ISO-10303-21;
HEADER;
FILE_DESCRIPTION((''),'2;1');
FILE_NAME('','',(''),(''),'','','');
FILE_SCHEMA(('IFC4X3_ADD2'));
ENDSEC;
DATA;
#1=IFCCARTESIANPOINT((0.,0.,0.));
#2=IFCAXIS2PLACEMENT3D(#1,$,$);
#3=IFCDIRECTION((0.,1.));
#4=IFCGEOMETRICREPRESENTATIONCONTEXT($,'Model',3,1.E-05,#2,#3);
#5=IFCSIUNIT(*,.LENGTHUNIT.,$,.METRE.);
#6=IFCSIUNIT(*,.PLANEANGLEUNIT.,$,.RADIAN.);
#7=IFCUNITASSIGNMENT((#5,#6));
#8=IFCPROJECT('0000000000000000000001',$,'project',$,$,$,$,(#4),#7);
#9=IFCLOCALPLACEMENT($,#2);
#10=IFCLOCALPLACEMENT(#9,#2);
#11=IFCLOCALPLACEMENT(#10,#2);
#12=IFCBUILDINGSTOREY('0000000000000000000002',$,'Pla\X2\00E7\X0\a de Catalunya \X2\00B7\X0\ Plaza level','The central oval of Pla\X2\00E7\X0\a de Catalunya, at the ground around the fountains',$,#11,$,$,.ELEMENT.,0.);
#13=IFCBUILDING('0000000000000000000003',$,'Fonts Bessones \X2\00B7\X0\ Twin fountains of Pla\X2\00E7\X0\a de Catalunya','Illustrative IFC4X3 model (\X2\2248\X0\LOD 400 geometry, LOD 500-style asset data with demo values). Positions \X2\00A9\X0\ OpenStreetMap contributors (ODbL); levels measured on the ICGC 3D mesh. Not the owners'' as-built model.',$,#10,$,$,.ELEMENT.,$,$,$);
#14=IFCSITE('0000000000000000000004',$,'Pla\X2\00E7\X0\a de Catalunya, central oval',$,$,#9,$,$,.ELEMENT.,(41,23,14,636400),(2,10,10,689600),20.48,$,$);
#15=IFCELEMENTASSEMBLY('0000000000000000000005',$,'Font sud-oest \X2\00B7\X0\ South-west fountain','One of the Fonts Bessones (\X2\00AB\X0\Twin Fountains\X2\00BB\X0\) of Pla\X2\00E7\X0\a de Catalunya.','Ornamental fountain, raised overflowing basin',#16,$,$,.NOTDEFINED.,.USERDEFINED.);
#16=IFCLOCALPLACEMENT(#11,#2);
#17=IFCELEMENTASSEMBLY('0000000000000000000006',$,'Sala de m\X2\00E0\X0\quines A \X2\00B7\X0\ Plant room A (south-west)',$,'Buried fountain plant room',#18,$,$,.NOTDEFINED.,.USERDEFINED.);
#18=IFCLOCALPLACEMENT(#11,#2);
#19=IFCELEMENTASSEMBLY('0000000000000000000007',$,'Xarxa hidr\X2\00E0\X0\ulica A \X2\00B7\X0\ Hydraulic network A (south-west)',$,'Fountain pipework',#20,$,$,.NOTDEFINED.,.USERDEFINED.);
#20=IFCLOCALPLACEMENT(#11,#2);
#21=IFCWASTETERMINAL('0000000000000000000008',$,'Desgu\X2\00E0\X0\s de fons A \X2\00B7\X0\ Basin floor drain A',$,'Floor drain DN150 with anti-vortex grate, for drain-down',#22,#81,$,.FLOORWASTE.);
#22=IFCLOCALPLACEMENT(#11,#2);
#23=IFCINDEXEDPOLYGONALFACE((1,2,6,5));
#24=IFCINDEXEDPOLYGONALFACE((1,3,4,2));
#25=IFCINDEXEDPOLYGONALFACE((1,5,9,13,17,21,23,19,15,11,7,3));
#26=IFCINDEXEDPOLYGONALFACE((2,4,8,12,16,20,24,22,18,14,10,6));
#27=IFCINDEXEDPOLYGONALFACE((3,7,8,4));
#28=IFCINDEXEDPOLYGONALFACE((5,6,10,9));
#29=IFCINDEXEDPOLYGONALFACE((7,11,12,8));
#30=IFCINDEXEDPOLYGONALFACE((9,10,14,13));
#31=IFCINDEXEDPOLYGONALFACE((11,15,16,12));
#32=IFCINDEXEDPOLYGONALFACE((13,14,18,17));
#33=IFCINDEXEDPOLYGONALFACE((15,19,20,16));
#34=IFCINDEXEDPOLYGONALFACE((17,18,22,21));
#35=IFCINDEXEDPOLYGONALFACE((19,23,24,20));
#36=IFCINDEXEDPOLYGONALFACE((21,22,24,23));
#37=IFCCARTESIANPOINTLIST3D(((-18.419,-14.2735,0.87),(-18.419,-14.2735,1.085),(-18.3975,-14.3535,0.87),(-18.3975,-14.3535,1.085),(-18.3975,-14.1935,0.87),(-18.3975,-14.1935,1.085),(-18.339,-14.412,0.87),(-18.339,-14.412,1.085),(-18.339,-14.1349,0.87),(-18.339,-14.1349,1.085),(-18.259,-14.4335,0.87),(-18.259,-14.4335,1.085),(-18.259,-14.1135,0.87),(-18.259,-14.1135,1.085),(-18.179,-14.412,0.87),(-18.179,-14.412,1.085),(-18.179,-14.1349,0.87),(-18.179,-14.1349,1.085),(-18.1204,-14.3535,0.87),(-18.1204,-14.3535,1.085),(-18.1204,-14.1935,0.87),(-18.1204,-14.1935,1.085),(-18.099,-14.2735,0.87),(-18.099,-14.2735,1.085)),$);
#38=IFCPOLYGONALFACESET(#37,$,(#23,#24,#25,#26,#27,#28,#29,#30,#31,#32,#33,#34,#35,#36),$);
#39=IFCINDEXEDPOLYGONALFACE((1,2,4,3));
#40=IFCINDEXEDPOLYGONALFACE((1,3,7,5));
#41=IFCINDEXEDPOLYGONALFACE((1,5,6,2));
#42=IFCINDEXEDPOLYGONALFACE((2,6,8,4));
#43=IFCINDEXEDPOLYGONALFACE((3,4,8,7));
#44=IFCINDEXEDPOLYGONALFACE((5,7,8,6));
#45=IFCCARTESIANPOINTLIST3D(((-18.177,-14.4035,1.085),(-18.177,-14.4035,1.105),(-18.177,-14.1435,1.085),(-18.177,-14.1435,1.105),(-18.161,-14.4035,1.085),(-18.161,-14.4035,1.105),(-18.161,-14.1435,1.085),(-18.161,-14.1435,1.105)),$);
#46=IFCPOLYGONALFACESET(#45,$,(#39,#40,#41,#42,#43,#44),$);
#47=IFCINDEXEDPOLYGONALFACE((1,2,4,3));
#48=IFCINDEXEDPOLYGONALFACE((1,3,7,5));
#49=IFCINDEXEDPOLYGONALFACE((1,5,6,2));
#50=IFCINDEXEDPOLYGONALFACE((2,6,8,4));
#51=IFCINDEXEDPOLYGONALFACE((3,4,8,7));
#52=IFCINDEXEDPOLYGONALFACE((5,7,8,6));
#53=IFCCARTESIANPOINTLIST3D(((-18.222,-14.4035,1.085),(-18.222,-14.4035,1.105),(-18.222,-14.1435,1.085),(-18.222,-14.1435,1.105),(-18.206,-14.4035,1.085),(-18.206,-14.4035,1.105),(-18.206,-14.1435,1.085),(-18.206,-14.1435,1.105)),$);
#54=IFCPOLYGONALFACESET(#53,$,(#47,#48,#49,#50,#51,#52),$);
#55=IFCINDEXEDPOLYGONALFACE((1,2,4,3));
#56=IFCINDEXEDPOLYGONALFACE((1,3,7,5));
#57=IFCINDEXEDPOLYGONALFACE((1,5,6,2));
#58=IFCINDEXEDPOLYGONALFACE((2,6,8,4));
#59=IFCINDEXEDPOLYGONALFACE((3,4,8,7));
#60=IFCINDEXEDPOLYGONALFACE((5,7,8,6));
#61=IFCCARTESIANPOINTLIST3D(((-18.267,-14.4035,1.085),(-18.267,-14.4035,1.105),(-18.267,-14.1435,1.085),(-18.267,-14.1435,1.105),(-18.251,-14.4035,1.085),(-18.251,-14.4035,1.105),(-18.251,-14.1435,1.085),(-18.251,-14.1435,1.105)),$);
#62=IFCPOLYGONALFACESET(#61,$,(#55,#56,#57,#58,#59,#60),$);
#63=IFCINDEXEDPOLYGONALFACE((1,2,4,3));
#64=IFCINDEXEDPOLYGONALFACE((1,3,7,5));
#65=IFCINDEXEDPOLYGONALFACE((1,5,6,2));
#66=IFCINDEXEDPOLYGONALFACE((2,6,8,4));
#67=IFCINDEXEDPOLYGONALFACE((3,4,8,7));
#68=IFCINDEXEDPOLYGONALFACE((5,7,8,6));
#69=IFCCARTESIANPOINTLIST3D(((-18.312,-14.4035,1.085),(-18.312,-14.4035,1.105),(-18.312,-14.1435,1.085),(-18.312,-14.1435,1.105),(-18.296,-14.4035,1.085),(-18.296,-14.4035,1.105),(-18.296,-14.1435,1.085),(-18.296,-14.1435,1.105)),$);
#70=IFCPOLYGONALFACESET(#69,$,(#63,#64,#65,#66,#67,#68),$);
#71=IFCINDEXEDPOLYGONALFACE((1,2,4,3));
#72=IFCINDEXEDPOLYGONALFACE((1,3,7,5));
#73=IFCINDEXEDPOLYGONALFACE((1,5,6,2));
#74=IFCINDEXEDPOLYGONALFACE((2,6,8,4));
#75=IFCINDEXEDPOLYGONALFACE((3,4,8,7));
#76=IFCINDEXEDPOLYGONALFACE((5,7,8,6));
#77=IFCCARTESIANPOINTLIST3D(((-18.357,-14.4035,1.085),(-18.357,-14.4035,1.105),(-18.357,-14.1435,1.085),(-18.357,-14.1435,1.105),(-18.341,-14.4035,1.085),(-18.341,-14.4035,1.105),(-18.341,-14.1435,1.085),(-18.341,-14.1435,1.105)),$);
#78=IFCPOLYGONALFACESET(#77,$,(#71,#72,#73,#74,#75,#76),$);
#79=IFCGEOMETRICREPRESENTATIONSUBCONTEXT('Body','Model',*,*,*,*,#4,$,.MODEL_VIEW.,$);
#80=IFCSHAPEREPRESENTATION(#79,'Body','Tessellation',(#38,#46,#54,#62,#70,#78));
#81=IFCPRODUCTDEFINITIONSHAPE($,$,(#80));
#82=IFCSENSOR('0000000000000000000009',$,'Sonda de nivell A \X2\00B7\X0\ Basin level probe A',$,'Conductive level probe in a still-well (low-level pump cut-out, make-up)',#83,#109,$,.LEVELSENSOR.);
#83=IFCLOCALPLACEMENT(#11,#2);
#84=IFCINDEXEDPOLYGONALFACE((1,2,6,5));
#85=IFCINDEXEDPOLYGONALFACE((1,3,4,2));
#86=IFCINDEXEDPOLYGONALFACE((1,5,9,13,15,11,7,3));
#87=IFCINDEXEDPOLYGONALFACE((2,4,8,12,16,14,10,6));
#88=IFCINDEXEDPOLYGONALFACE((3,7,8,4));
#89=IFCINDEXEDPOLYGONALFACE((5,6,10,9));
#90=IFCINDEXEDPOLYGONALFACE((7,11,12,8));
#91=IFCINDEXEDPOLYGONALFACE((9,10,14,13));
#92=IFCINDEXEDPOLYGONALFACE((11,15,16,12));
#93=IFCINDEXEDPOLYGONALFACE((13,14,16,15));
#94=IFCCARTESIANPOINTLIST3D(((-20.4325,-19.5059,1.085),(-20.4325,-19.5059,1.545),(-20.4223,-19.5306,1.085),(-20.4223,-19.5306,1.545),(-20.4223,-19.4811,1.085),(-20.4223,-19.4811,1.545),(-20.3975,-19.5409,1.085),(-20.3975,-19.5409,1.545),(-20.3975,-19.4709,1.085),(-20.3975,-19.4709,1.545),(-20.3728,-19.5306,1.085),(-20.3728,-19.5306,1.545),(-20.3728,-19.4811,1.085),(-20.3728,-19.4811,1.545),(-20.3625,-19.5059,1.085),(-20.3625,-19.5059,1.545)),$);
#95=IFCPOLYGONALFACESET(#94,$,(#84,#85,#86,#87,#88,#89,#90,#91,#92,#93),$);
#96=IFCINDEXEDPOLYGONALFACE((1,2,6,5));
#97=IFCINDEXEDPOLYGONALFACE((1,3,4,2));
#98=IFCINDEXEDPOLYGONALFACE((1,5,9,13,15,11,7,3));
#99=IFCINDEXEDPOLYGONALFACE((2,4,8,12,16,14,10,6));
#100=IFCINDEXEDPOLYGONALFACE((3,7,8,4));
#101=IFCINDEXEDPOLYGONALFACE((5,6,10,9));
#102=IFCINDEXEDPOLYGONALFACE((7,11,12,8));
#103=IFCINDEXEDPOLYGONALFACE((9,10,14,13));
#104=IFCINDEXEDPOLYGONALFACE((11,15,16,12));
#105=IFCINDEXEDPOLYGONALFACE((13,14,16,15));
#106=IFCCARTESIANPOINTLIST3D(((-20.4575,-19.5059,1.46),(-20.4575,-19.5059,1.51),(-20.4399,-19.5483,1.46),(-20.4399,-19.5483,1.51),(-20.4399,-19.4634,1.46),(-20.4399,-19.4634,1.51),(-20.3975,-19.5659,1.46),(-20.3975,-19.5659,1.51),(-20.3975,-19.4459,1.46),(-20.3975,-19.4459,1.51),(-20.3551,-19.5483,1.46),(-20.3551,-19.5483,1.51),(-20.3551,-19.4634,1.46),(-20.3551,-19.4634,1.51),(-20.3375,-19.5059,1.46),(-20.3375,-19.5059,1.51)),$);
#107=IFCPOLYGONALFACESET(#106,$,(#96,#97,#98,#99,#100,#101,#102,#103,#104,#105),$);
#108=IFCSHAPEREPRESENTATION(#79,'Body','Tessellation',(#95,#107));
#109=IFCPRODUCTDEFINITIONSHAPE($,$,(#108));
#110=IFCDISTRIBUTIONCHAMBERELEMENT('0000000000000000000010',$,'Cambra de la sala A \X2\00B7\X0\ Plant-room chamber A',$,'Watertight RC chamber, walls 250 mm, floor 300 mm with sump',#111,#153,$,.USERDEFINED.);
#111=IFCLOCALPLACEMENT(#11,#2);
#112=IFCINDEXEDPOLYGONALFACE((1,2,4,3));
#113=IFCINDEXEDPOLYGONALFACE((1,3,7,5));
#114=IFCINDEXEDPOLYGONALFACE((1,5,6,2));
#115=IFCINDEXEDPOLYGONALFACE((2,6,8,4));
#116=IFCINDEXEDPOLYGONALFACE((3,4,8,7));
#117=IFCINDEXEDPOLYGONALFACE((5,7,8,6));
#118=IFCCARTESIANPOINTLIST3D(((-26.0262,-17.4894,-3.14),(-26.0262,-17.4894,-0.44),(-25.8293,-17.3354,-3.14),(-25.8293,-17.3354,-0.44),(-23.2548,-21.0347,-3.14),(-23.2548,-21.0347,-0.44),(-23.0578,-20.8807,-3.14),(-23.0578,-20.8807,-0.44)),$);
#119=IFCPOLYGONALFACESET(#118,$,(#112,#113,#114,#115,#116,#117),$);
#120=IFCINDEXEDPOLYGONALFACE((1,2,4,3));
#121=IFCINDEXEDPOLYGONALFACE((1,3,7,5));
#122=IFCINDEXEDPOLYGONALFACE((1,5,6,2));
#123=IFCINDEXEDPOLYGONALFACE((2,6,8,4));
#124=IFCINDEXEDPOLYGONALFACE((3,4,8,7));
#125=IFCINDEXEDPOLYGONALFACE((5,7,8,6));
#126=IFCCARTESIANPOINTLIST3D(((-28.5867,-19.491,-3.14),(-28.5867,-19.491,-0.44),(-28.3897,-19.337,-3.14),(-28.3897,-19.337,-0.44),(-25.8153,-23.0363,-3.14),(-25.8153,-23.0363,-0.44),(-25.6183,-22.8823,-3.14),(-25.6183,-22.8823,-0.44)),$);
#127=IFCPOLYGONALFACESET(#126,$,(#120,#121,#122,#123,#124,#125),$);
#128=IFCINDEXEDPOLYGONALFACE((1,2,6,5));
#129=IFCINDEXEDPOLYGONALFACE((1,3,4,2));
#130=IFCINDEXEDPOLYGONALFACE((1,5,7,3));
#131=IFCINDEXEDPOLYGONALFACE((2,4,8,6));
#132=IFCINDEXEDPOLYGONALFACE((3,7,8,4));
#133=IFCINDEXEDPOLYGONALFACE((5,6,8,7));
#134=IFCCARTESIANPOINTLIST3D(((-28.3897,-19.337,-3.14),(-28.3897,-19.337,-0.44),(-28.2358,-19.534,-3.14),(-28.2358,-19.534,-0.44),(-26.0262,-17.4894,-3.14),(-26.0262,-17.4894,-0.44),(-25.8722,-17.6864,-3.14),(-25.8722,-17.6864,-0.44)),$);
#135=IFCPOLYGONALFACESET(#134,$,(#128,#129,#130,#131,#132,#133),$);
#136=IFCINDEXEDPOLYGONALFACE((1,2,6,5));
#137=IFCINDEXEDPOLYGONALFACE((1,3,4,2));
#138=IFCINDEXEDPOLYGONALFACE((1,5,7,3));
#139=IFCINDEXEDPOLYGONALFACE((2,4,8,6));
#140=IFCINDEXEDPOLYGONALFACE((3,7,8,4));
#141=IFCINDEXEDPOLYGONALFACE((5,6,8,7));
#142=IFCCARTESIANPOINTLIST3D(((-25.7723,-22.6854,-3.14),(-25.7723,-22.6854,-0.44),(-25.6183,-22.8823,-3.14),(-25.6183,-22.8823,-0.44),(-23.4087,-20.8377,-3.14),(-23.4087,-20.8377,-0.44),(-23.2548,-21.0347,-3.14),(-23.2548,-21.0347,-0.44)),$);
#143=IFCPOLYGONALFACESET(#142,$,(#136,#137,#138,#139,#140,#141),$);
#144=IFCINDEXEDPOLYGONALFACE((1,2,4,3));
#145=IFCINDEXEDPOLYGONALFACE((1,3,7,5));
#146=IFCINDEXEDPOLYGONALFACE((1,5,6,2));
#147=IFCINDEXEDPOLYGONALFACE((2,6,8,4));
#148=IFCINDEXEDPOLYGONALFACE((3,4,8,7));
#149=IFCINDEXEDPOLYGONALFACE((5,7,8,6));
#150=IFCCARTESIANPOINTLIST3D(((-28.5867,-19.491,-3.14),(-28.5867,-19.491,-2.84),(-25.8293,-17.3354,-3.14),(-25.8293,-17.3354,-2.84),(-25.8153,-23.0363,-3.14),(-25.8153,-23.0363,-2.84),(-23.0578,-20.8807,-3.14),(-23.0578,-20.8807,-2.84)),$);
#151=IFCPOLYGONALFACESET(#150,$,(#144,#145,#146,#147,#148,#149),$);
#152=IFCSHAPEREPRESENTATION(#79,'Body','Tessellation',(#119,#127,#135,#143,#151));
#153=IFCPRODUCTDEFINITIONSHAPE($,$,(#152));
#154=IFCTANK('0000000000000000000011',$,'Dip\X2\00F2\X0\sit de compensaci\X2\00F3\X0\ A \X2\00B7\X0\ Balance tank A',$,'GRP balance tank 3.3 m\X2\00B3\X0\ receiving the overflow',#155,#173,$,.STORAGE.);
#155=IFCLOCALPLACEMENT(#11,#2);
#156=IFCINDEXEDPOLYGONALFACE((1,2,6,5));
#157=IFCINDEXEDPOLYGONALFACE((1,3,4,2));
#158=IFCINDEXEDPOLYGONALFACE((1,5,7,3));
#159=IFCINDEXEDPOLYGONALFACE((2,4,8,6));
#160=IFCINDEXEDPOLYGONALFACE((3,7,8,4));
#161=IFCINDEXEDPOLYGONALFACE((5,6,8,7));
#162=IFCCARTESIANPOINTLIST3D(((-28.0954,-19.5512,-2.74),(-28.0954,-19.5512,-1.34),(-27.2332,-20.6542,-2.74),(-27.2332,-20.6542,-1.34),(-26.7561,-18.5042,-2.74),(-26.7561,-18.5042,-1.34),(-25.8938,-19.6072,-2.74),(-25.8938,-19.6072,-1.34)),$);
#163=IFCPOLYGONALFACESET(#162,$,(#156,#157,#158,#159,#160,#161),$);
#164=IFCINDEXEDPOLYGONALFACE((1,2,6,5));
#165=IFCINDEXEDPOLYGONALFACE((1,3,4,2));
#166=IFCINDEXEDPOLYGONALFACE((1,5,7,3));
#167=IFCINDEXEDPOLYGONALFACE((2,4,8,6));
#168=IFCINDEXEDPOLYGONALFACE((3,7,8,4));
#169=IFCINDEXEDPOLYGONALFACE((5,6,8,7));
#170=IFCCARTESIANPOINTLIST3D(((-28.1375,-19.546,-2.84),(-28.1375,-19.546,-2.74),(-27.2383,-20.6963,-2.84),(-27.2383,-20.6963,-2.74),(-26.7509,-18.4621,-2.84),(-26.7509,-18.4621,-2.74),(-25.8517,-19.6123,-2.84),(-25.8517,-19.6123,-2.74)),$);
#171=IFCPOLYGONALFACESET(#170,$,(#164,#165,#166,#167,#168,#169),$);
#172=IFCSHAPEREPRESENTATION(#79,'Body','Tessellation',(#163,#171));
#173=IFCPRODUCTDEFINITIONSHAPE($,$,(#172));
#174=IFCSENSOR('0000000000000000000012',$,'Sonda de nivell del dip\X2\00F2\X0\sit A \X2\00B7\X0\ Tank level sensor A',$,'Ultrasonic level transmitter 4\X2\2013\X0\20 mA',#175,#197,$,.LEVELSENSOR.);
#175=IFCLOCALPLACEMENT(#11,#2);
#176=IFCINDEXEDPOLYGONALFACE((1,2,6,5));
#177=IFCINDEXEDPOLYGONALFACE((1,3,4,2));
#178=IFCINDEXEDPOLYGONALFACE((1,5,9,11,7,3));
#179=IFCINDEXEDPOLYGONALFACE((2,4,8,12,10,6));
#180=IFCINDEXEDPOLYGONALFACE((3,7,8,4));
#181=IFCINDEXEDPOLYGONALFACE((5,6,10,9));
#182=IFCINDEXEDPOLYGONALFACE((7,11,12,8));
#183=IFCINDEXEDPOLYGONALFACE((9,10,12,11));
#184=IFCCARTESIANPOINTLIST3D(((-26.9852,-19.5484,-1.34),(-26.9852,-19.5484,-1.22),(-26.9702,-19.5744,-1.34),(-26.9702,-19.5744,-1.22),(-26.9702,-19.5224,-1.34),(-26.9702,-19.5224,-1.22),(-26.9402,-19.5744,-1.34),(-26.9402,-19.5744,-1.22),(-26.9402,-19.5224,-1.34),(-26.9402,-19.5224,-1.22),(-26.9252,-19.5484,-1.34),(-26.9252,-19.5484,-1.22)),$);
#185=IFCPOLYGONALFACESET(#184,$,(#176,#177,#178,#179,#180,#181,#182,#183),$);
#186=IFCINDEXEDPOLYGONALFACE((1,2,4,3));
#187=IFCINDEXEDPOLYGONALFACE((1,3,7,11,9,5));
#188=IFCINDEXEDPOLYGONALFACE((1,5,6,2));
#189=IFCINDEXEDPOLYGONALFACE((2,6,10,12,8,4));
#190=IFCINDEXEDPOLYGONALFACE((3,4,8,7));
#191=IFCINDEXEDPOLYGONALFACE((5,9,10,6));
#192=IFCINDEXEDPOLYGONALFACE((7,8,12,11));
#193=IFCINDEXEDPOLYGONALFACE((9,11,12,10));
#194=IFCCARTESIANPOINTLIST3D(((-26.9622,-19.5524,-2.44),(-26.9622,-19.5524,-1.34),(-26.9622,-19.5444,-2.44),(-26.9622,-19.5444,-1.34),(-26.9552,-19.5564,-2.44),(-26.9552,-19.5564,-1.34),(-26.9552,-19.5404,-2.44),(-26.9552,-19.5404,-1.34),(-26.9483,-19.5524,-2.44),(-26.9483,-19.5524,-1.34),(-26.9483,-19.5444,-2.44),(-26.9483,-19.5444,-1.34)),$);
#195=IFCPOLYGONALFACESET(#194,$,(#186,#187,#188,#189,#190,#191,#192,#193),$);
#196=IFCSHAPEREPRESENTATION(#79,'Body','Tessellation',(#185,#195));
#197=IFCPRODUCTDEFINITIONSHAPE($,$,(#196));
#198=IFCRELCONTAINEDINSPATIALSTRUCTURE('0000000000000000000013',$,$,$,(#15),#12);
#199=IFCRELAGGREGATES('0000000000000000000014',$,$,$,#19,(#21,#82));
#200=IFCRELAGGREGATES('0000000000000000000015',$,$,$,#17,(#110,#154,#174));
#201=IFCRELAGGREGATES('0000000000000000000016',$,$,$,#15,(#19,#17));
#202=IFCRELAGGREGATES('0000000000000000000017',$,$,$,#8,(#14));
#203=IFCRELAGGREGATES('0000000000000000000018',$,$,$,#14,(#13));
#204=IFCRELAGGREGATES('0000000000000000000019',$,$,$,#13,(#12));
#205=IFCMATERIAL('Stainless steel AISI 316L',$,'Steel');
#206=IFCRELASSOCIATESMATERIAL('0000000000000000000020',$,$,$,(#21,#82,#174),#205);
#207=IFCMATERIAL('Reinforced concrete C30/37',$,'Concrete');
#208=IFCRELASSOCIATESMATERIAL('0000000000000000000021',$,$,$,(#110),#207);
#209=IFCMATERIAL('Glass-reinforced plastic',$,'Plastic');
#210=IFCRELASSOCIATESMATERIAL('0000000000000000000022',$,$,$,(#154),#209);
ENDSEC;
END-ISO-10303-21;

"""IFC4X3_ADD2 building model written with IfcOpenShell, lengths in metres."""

from ifc_helpers import new_model, si_unit, direction, frame, frame_2d, origin, place, context, subcontext, project, spatial, polyline, rectangle, outline, extrude, material, element, aggregate, save


model = new_model("IFC4X3_ADD2")

# Units and contexts
model_context = context("Model", 3, precision=1e-05, world=origin(), true_north=direction((0.0, 1.0)))
body_context = subcontext(model_context, "Body", "Model", "MODEL_VIEW")
ifc_project = project(units=[si_unit("LENGTHUNIT", "METRE"), si_unit("PLANEANGLEUNIT", "RADIAN")], contexts=[model_context])

# Site, building, storey
site_placement = place(None, origin())
site = spatial("IfcSite", under=ifc_project, at=site_placement, Name="Plaça de Catalunya, central oval", CompositionType="ELEMENT", RefLatitude=(41, 23, 14, 636400), RefLongitude=(2, 10, 10, 689600), RefElevation=20.48)
building_placement = place(site_placement, origin())
building = spatial("IfcBuilding", under=site, at=building_placement, Name="Fonts Bessones · Twin fountains of Plaça de Catalunya", Description="Illustrative IFC4X3 model (≈LOD 400 geometry, LOD 500-style asset data with demo values). Positions © OpenStreetMap contributors (ODbL); levels measured on the ICGC 3D mesh. Not the owners' as-built model.", CompositionType="ELEMENT")
storey_placement = place(building_placement, origin())
storey = spatial("IfcBuildingStorey", under=building, at=storey_placement, Name="Plaça de Catalunya · Plaza level", Description="The central oval of Plaça de Catalunya, at the ground around the fountains", CompositionType="ELEMENT", Elevation=0.0)

# Shared definitions
ifc_material_1 = material(Name="Reinforced concrete C30/37", Category="Concrete")

# Element assemblies
assembly_1_placement = place(building_placement, origin())
assembly_1 = element("IfcElementAssembly", 1, at=assembly_1_placement, inside=storey, Name="Font sud-oest · South-west fountain", Description="One of the Fonts Bessones («Twin Fountains») of Plaça de Catalunya.", ObjectType="Ornamental fountain, raised overflowing basin", AssemblyPlace="NOTDEFINED", PredefinedType="USERDEFINED")
assembly_2_placement = place(building_placement, origin())
assembly_2 = element("IfcElementAssembly", 2, at=assembly_2_placement, Name="Sala de màquines A · Plant room A (south-west)", ObjectType="Buried fountain plant room", AssemblyPlace="NOTDEFINED", PredefinedType="USERDEFINED")

# Shared definitions
ifc_material_2 = material(Name="Stainless steel AISI 316L", Category="Steel")

# Element assembly, waste terminal, sensor
assembly_3_placement = place(building_placement, origin())
assembly_3 = element("IfcElementAssembly", 3, at=assembly_3_placement, Name="Xarxa hidràulica A · Hydraulic network A (south-west)", ObjectType="Fountain pipework", AssemblyPlace="NOTDEFINED", PredefinedType="USERDEFINED")
waste_terminal_placement = place(building_placement, origin())
waste_terminal = element("IfcWasteTerminal", 4, at=waste_terminal_placement, material=ifc_material_2, Name="Desguàs de fons A · Basin floor drain A", ObjectType="Floor drain DN150 with anti-vortex grate, for drain-down", PredefinedType="FLOORWASTE", context=body_context, shape_type="SweptSolid", body=[
    extrude(outline(polyline([(-18.099, -14.2735), (-18.1204, -14.1935), (-18.179, -14.1349), (-18.259, -14.1135), (-18.339, -14.1349), (-18.3975, -14.1935), (-18.419, -14.2735), (-18.3975, -14.3535), (-18.339, -14.412), (-18.259, -14.4335), (-18.179, -14.412), (-18.1204, -14.3535), (-18.099, -14.2735)])), frame((0.0, 0.0, 0.87)), (0.0, 0.0, 1.0), 0.215),
    extrude(rectangle(XDim=0.26, YDim=0.016, at=frame_2d((0.0, 0.0), x_axis=(0.0, 1.0))), frame((-18.169, -14.2735, 1.085)), (0.0, 0.0, 1.0), 0.02),
    extrude(rectangle(XDim=0.26, YDim=0.016, at=frame_2d((0.0, 0.0), x_axis=(0.0, 1.0))), frame((-18.214, -14.2735, 1.085)), (0.0, 0.0, 1.0), 0.02),
    extrude(rectangle(XDim=0.26, YDim=0.016, at=frame_2d((0.0, 0.0), x_axis=(0.0, 1.0))), frame((-18.259, -14.2735, 1.085)), (0.0, 0.0, 1.0), 0.02),
    extrude(rectangle(XDim=0.26, YDim=0.016, at=frame_2d((0.0, 0.0), x_axis=(0.0, 1.0))), frame((-18.304, -14.2735, 1.085)), (0.0, 0.0, 1.0), 0.02),
    extrude(rectangle(XDim=0.26, YDim=0.016, at=frame_2d((0.0, 0.0), x_axis=(0.0, 1.0))), frame((-18.349, -14.2735, 1.085)), (0.0, 0.0, 1.0), 0.02),
])
sensor_1_placement = place(building_placement, origin())
sensor_1 = element("IfcSensor", 5, at=sensor_1_placement, material=ifc_material_2, Name="Sonda de nivell A · Basin level probe A", ObjectType="Conductive level probe in a still-well (low-level pump cut-out, make-up)", PredefinedType="LEVELSENSOR", context=body_context, shape_type="SweptSolid", body=[
    extrude(outline(polyline([(-20.3625, -19.5059), (-20.3728, -19.4811), (-20.3975, -19.4709), (-20.4223, -19.4811), (-20.4325, -19.5059), (-20.4223, -19.5306), (-20.3975, -19.5409), (-20.3728, -19.5306), (-20.3625, -19.5059)])), frame((0.0, 0.0, 1.085)), (0.0, 0.0, 1.0), 0.46),
    extrude(outline(polyline([(-20.3375, -19.5059), (-20.3551, -19.4634), (-20.3975, -19.4459), (-20.4399, -19.4634), (-20.4575, -19.5059), (-20.4399, -19.5483), (-20.3975, -19.5659), (-20.3551, -19.5483), (-20.3375, -19.5059)])), frame((0.0, 0.0, 1.46)), (0.0, 0.0, 1.0), 0.05),
])

# Distribution chamber element
distribution_chamber_element_placement = place(building_placement, origin())
distribution_chamber_element = element("IfcDistributionChamberElement", 6, at=distribution_chamber_element_placement, material=ifc_material_1, Name="Cambra de la sala A · Plant-room chamber A", ObjectType="Watertight RC chamber, walls 250 mm, floor 300 mm with sump", PredefinedType="USERDEFINED", context=body_context, shape_type="SweptSolid", body=[
    extrude(rectangle(XDim=4.5, YDim=0.25, at=frame_2d((0.0, 0.0), x_axis=(0.615875, -0.787844))), frame((-24.542, -19.1851, -3.14)), (0.0, 0.0, 1.0), 2.7),
    extrude(rectangle(XDim=4.5, YDim=0.25, at=frame_2d((0.0, 0.0), x_axis=(0.615875, -0.787844))), frame((-27.1025, -21.1867, -3.14)), (0.0, 0.0, 1.0), 2.7),
    extrude(rectangle(XDim=0.25, YDim=3.0, at=frame_2d((0.0, 0.0), x_axis=(0.615875, -0.787844))), frame((-27.131, -18.5117, -3.14)), (0.0, 0.0, 1.0), 2.7),
    extrude(rectangle(XDim=0.25, YDim=3.0, at=frame_2d((0.0, 0.0), x_axis=(0.615875, -0.787844))), frame((-24.5135, -21.86, -3.14)), (0.0, 0.0, 1.0), 2.7),
    extrude(rectangle(XDim=4.5, YDim=3.5, at=frame_2d((0.0, 0.0), x_axis=(0.615875, -0.787844))), frame((-25.8223, -20.1859, -3.14)), (0.0, 0.0, 1.0), 0.3),
])

# Tank
ifc_material_3 = material(Name="Glass-reinforced plastic", Category="Plastic")
tank_placement = place(building_placement, origin())
tank = element("IfcTank", 7, at=tank_placement, material=ifc_material_3, Name="Dipòsit de compensació A · Balance tank A", ObjectType="GRP balance tank 3.3 m³ receiving the overflow", PredefinedType="STORAGE", context=body_context, shape_type="SweptSolid", body=[
    extrude(rectangle(XDim=1.4, YDim=1.7, at=frame_2d((0.0, 0.0), x_axis=(0.615875, -0.787844))), frame((-26.9946, -19.5792, -2.74)), (0.0, 0.0, 1.0), 1.4),
    extrude(rectangle(XDim=1.46, YDim=1.76, at=frame_2d((0.0, 0.0), x_axis=(0.615875, -0.787844))), frame((-26.9946, -19.5792, -2.84)), (0.0, 0.0, 1.0), 0.1),
])

# Sensor
sensor_2_placement = place(building_placement, origin())
sensor_2 = element("IfcSensor", 8, at=sensor_2_placement, material=ifc_material_2, Name="Sonda de nivell del dipòsit A · Tank level sensor A", ObjectType="Ultrasonic level transmitter 4–20 mA", PredefinedType="LEVELSENSOR", context=body_context, shape_type="SweptSolid", body=[
    extrude(outline(polyline([(-26.9252, -19.5484), (-26.9402, -19.5224), (-26.9702, -19.5224), (-26.9852, -19.5484), (-26.9702, -19.5744), (-26.9402, -19.5744), (-26.9252, -19.5484)])), frame((0.0, 0.0, -1.34)), (0.0, 0.0, 1.0), 0.12),
    extrude(outline(polyline([(0.008, 0.0), (0.004, 0.0069), (-0.004, 0.0069), (-0.008, 0.0), (-0.004, -0.0069), (0.004, -0.0069), (0.008, 0.0)])), frame((-26.9552, -19.5484, -1.34), z_axis=(0.0, 0.0, -1.0), x_axis=(0.0, -1.0, 0.0)), (0.0, 0.0, 1.0), 1.1),
])

aggregate(assembly_3, [waste_terminal, sensor_1])

aggregate(assembly_2, [distribution_chamber_element, tank, sensor_2])

aggregate(assembly_1, [assembly_3, assembly_2])

save(model, "model.ifc")
